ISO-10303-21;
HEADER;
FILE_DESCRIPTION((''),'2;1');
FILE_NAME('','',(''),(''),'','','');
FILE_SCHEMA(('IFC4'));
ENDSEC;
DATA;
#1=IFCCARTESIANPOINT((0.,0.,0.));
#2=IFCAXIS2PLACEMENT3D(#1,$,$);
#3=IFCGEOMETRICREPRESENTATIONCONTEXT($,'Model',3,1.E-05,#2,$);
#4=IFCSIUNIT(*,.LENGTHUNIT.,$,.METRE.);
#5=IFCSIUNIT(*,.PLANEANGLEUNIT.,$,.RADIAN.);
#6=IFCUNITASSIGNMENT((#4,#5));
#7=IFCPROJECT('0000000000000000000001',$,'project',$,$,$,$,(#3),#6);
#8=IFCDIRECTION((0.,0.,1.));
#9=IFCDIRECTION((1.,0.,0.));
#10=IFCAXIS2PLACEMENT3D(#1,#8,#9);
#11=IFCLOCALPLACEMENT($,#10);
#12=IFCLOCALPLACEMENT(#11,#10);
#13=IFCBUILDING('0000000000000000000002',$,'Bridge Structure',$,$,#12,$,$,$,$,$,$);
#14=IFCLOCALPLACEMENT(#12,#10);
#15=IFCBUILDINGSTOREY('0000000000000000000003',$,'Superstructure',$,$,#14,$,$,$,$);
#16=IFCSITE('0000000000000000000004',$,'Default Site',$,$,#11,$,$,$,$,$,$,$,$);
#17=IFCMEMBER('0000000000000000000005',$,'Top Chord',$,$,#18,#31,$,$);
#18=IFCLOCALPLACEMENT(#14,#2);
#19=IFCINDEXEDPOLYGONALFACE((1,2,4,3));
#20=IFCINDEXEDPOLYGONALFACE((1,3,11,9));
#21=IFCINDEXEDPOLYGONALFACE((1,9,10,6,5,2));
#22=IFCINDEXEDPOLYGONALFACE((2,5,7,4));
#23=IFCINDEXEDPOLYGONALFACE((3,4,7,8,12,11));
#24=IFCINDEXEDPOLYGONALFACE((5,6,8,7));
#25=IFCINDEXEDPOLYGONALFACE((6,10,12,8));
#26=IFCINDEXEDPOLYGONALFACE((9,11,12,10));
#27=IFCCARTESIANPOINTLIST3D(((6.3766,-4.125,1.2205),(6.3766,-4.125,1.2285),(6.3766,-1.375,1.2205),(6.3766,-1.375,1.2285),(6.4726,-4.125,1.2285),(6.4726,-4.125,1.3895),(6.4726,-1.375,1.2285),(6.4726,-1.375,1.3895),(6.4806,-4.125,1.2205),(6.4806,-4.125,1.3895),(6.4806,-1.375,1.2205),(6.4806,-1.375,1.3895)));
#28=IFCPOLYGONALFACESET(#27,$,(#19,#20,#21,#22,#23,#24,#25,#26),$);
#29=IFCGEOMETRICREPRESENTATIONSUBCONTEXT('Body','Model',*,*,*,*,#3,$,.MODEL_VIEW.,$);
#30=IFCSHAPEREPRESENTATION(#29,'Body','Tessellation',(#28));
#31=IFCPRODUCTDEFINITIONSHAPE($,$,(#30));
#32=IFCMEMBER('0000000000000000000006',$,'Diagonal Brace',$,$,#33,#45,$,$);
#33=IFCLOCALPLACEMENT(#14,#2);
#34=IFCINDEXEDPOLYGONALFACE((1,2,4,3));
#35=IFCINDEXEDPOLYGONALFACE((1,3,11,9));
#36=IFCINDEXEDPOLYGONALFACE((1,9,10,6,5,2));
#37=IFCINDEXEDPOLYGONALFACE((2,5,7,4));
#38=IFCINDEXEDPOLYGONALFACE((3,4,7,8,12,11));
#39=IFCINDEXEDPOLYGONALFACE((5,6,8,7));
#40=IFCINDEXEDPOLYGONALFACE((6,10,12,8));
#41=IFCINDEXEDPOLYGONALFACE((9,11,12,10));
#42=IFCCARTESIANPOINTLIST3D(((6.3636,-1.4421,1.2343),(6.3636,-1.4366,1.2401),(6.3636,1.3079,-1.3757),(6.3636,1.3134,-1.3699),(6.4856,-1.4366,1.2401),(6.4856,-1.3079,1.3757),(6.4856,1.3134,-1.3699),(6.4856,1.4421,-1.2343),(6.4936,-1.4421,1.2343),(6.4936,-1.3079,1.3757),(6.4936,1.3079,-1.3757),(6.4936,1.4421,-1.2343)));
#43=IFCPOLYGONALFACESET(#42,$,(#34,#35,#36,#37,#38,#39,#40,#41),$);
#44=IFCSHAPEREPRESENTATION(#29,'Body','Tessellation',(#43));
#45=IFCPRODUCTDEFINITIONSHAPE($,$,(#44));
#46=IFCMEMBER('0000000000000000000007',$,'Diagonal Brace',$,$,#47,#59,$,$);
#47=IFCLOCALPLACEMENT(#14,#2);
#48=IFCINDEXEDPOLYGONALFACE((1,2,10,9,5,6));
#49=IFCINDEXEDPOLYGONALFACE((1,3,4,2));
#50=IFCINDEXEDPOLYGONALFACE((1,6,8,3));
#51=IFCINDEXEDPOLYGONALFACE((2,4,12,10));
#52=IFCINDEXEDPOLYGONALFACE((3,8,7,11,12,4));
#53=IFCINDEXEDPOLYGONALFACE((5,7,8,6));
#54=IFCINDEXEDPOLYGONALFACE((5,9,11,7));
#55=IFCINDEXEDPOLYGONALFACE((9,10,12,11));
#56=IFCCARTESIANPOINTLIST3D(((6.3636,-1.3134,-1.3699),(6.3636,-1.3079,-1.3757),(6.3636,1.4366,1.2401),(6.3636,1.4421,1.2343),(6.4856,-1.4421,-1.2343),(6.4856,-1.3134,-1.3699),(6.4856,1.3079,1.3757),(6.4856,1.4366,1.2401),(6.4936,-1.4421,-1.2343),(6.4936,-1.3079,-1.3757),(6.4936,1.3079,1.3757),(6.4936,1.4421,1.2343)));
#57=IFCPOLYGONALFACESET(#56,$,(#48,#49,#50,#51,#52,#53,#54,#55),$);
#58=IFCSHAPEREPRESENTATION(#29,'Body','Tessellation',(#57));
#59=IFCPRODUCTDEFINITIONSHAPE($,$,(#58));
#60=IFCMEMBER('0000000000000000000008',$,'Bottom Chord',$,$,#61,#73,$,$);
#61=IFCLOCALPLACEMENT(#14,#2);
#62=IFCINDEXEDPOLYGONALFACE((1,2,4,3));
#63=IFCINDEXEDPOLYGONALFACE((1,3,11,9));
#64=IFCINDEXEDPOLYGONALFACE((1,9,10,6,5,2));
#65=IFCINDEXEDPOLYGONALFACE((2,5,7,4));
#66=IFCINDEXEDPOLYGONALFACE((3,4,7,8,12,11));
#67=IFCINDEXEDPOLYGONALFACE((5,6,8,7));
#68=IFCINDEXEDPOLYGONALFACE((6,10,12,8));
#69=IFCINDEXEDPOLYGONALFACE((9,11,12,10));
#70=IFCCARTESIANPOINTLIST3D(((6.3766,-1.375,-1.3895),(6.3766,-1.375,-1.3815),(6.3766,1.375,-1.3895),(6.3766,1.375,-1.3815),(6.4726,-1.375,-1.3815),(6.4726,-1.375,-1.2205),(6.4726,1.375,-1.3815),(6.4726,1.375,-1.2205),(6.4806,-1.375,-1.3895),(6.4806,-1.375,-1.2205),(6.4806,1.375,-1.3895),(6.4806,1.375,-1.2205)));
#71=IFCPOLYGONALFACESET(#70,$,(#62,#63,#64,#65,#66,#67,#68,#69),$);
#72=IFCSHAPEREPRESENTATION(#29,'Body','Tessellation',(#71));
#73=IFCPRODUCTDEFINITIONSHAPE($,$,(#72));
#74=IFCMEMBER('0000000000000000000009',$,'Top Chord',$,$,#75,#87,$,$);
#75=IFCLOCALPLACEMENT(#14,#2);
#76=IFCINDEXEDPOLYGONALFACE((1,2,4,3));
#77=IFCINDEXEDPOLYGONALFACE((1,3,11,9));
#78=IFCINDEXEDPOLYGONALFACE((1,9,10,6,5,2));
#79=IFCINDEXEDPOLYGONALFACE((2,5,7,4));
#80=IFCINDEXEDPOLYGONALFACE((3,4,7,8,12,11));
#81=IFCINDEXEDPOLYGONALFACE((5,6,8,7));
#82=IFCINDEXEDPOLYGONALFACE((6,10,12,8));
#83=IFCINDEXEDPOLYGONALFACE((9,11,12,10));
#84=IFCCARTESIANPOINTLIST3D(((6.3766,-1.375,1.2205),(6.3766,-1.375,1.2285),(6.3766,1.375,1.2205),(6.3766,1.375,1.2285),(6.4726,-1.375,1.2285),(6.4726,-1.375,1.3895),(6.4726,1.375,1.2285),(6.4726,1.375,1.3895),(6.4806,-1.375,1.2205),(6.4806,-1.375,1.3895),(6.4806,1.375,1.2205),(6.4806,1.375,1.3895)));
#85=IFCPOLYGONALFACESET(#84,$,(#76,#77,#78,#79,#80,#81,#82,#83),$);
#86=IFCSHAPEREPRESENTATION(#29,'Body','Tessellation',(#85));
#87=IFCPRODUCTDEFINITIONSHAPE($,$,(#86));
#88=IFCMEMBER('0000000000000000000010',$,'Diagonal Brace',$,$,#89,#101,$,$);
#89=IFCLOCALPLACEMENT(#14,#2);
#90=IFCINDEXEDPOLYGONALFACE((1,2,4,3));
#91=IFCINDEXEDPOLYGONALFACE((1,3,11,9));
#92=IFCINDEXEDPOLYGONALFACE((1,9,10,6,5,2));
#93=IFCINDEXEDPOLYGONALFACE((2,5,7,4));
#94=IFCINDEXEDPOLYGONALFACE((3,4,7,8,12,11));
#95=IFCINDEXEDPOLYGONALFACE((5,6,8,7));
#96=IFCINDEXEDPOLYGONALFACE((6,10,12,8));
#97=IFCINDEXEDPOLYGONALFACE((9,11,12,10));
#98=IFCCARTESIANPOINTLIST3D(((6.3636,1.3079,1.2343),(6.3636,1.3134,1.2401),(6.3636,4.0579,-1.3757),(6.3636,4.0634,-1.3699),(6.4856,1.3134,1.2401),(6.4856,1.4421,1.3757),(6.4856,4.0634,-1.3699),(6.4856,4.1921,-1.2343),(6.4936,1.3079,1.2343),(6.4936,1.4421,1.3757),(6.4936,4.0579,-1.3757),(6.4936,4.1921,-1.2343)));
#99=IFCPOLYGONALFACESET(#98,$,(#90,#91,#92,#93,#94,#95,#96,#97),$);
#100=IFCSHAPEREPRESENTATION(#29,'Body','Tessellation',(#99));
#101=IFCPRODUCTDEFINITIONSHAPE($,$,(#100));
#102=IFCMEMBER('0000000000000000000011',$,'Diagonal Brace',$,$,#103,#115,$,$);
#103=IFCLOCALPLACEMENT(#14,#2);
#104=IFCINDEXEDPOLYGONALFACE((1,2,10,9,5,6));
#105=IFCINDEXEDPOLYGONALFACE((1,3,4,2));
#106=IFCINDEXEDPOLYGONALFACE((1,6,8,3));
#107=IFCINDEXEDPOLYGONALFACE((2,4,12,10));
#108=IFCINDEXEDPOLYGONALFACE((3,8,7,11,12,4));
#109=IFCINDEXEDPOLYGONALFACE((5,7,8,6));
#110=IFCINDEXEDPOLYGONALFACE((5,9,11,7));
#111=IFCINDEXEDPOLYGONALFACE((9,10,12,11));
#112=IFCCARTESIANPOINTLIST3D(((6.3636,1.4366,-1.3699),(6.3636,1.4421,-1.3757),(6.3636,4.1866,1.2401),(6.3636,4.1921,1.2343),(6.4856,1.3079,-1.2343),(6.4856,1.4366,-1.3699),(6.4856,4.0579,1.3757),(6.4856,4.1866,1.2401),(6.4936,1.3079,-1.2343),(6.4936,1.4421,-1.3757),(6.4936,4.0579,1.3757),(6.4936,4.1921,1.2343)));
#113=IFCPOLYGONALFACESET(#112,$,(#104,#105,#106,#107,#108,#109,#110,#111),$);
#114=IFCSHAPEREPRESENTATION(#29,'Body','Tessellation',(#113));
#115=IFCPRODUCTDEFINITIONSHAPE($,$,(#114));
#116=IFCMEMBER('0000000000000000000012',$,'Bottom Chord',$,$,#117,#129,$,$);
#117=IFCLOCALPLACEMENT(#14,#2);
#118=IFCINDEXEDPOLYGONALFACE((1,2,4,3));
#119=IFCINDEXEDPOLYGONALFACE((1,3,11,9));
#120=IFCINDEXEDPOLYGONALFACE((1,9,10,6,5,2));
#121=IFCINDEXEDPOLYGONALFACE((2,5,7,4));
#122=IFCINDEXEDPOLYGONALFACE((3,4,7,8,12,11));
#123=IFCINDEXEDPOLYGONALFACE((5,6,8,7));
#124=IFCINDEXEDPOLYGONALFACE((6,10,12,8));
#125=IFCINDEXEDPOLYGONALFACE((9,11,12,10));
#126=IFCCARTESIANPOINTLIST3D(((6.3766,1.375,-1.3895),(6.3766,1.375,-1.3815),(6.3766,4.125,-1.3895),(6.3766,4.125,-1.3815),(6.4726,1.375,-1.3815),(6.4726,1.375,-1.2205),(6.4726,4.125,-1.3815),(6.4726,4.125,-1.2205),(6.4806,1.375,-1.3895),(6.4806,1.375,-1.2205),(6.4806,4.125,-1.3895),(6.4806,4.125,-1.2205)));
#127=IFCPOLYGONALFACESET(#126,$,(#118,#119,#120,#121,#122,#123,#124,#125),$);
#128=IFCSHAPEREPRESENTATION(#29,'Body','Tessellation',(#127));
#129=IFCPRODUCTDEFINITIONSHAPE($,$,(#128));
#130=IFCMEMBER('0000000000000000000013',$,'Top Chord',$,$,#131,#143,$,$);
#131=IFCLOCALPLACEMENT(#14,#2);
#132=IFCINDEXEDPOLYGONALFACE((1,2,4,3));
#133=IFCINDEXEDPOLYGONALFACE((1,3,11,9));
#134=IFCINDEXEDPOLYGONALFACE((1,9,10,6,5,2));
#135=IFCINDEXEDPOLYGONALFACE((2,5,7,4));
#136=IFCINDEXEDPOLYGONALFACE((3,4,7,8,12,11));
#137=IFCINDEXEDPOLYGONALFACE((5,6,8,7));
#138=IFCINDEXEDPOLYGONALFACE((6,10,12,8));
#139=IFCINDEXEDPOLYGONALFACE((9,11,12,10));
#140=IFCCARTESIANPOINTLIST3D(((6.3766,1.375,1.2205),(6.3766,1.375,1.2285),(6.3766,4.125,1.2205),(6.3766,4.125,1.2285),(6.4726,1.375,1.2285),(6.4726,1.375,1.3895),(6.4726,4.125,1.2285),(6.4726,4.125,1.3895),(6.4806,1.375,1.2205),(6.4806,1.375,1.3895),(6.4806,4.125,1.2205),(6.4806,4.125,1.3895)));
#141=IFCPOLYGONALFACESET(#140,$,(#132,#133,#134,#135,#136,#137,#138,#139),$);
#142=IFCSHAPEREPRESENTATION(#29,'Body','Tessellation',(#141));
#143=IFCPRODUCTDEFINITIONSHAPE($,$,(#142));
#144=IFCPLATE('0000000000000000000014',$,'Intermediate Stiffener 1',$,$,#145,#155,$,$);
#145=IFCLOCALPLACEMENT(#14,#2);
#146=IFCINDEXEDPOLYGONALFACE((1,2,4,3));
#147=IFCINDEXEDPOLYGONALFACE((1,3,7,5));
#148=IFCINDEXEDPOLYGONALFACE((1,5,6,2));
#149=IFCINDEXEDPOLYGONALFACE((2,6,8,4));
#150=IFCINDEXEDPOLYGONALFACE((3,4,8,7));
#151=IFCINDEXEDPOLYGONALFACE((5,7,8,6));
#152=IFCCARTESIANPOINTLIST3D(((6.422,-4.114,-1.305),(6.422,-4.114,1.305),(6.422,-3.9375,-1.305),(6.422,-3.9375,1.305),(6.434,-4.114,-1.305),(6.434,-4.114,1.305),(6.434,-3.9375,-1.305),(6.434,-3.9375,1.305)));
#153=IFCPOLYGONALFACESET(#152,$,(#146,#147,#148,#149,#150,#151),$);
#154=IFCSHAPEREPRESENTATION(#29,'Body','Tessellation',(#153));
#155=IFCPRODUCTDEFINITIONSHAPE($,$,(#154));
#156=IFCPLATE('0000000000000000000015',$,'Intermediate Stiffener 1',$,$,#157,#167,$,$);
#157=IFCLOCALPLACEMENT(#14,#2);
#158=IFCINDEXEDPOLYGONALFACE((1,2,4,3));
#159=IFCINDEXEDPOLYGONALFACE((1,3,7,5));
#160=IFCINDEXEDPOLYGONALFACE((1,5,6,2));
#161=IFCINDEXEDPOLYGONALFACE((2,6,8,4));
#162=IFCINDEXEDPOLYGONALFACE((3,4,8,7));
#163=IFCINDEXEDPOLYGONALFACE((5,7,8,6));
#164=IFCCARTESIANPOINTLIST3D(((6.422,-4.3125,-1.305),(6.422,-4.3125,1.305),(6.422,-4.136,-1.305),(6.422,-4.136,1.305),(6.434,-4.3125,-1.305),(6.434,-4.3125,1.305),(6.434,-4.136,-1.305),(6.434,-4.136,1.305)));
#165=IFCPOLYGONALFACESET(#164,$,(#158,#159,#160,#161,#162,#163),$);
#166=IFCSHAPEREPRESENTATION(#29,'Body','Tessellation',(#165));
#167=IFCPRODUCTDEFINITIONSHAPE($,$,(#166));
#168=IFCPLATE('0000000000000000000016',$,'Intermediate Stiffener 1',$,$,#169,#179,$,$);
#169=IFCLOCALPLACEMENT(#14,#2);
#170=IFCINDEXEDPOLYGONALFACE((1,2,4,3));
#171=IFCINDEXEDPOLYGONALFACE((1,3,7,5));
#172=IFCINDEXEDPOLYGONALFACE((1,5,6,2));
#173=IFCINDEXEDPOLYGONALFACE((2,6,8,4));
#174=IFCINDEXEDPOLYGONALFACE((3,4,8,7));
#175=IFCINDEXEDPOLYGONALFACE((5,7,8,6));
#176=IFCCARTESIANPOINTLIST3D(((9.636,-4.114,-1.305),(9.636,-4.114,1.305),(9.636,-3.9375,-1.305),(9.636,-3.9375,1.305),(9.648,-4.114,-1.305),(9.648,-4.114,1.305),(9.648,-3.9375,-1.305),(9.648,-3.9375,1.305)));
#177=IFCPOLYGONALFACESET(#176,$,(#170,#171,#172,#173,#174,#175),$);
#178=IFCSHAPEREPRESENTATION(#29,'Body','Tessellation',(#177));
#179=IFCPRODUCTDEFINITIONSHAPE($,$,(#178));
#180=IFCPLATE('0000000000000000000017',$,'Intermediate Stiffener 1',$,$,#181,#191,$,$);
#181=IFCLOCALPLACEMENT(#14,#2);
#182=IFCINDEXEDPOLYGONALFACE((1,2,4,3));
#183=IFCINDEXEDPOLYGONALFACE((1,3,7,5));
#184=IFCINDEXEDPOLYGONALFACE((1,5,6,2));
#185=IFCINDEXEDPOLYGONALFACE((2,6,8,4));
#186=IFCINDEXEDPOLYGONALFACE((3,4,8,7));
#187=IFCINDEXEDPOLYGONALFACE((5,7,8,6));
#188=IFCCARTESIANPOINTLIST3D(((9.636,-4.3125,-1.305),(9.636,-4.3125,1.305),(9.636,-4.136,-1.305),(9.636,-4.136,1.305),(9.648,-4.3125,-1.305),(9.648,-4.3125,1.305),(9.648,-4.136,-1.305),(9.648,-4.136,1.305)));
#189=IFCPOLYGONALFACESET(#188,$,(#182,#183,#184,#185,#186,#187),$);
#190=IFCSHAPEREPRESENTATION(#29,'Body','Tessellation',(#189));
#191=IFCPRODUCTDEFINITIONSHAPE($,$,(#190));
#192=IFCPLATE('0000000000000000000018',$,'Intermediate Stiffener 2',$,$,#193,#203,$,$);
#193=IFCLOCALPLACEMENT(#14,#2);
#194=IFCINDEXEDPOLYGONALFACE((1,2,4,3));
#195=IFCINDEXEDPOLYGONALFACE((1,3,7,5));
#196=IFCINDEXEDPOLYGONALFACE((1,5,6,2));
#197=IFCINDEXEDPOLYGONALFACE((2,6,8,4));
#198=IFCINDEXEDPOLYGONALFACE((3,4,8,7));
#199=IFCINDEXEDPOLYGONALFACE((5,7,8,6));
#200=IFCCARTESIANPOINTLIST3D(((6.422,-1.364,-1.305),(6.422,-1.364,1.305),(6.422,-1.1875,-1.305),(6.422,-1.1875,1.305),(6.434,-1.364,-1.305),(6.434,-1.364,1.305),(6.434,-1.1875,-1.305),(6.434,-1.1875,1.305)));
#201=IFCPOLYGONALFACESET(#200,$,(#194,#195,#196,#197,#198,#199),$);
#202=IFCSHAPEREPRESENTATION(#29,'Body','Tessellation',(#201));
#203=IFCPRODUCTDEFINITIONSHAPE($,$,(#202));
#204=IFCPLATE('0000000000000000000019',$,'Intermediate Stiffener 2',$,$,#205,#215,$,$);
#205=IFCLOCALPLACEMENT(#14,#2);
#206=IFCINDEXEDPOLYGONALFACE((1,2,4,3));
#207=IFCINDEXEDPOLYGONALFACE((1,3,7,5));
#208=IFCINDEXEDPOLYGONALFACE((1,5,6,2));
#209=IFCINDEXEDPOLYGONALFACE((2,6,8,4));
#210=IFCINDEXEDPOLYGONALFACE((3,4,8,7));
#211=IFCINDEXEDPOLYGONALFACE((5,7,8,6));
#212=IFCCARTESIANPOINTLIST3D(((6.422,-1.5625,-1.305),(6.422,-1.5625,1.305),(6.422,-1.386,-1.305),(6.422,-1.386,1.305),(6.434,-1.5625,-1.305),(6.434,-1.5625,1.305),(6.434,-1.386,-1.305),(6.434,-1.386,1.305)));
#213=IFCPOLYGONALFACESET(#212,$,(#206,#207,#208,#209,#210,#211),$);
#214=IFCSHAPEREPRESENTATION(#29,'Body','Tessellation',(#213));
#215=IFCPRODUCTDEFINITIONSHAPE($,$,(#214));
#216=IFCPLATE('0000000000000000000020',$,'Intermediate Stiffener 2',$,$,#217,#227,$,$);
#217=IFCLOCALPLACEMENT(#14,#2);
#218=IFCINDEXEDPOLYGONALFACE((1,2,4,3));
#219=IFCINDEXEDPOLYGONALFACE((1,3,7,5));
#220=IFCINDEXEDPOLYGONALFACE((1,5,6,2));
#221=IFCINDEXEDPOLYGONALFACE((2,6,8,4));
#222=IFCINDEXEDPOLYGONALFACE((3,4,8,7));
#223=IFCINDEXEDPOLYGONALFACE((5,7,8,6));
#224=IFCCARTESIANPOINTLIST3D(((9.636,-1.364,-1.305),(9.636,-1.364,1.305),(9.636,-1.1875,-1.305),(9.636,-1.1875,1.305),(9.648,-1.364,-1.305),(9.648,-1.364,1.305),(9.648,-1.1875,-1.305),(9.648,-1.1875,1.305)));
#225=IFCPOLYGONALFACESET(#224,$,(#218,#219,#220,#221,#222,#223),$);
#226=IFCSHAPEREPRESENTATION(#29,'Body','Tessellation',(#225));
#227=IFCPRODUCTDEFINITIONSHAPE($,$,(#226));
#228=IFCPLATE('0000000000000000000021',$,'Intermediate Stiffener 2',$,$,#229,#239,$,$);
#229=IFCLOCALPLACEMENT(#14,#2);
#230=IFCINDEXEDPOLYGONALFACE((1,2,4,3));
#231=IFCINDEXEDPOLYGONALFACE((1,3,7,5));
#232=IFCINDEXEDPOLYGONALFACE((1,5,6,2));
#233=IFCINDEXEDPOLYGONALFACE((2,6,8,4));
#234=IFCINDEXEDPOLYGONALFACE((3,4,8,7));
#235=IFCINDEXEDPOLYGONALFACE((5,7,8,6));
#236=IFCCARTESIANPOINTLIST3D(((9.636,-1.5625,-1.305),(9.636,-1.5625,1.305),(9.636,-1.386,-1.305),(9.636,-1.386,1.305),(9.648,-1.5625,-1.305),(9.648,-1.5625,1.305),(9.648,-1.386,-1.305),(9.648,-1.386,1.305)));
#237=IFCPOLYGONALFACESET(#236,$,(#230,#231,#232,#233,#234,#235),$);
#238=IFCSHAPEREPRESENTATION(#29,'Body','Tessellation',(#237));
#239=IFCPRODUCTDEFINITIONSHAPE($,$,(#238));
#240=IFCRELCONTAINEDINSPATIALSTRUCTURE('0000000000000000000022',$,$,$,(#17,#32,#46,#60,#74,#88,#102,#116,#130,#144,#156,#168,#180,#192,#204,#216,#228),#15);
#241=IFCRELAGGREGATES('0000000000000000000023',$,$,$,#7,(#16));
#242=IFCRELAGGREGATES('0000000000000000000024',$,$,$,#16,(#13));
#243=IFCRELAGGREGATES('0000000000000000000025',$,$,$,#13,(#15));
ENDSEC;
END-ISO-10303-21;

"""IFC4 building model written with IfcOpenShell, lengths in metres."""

from ifc_helpers import new_model, si_unit, frame, origin, origin_with_axes, origin_2d_with_axis, place, context, subcontext, project, spatial, rectangle, l_section, extrude, element, save


model = new_model("IFC4")

# Units and contexts
model_context = context("Model", 3, precision=1e-05, world=origin())
body_context = subcontext(model_context, "Body", "Model", "MODEL_VIEW")
ifc_project = project(units=[si_unit("LENGTHUNIT", "METRE"), si_unit("PLANEANGLEUNIT", "RADIAN")], contexts=[model_context])

# Site, building, storey
site_placement = place(None, origin_with_axes())
site = spatial("IfcSite", under=ifc_project, at=site_placement, Name="Default Site")
building_placement = place(site_placement, origin_with_axes())
building = spatial("IfcBuilding", under=site, at=building_placement, Name="Bridge Structure")
storey_placement = place(building_placement, origin_with_axes())
storey = spatial("IfcBuildingStorey", under=building, at=storey_placement, Name="Superstructure")

# Members
for number, where, z_axis, x_axis, name in (
    (1, (6.4286, -4.125, 1.305), (0.0, 1.0, 0.0), (-1.0, 0.0, 0.0), "Top Chord"),
):
    element("IfcMember", number, at=place(storey_placement, frame(where, z_axis=z_axis, x_axis=x_axis)), inside=storey, Name=name, context=body_context, shape_type="SweptSolid", body=[
        extrude(l_section(Depth=0.169, Width=0.104, Thickness=0.008, at=origin_2d_with_axis()), origin_with_axes(), (0.0, 0.0, 1.0), 2.75),
    ])
for number, where, z_axis, x_axis, name in (
    (2, (6.4286, -1.375, 1.305), (0.0, 0.725329, -0.688403), (-1.0, 0.0, 0.0), "Diagonal Brace"),
    (3, (6.4286, -1.375, -1.305), (0.0, 0.725329, 0.688403), (-1.0, 0.0, 0.0), "Diagonal Brace"),
):
    element("IfcMember", number, at=place(storey_placement, frame(where, z_axis=z_axis, x_axis=x_axis)), inside=storey, Name=name, context=body_context, shape_type="SweptSolid", body=[
        extrude(l_section(Depth=0.195, Width=0.13, Thickness=0.008, at=origin_2d_with_axis()), origin_with_axes(), (0.0, 0.0, 1.0), 3.7914),
    ])
for number, where, z_axis, x_axis, name in (
    (4, (6.4286, -1.375, -1.305), (0.0, 1.0, 0.0), (-1.0, 0.0, 0.0), "Bottom Chord"),
    (5, (6.4286, -1.375, 1.305), (0.0, 1.0, 0.0), (-1.0, 0.0, 0.0), "Top Chord"),
):
    element("IfcMember", number, at=place(storey_placement, frame(where, z_axis=z_axis, x_axis=x_axis)), inside=storey, Name=name, context=body_context, shape_type="SweptSolid", body=[
        extrude(l_section(Depth=0.169, Width=0.104, Thickness=0.008, at=origin_2d_with_axis()), origin_with_axes(), (0.0, 0.0, 1.0), 2.75),
    ])
for number, where, z_axis, x_axis, name in (
    (6, (6.4286, 1.375, 1.305), (0.0, 0.725329, -0.688403), (-1.0, 0.0, 0.0), "Diagonal Brace"),
    (7, (6.4286, 1.375, -1.305), (0.0, 0.725329, 0.688403), (-1.0, 0.0, 0.0), "Diagonal Brace"),
):
    element("IfcMember", number, at=place(storey_placement, frame(where, z_axis=z_axis, x_axis=x_axis)), inside=storey, Name=name, context=body_context, shape_type="SweptSolid", body=[
        extrude(l_section(Depth=0.195, Width=0.13, Thickness=0.008, at=origin_2d_with_axis()), origin_with_axes(), (0.0, 0.0, 1.0), 3.7914),
    ])
for number, where, z_axis, x_axis, name in (
    (8, (6.4286, 1.375, -1.305), (0.0, 1.0, 0.0), (-1.0, 0.0, 0.0), "Bottom Chord"),
    (9, (6.4286, 1.375, 1.305), (0.0, 1.0, 0.0), (-1.0, 0.0, 0.0), "Top Chord"),
):
    element("IfcMember", number, at=place(storey_placement, frame(where, z_axis=z_axis, x_axis=x_axis)), inside=storey, Name=name, context=body_context, shape_type="SweptSolid", body=[
        extrude(l_section(Depth=0.169, Width=0.104, Thickness=0.008, at=origin_2d_with_axis()), origin_with_axes(), (0.0, 0.0, 1.0), 2.75),
    ])

# Plates
for number, where, z_axis, x_axis, name in (
    (10, (6.428, -4.0258, -1.305), (0.0, 0.0, 1.0), (1.0, 0.0, 0.0), "Intermediate Stiffener 1"),
    (11, (6.428, -4.2243, -1.305), (0.0, 0.0, 1.0), (1.0, 0.0, 0.0), "Intermediate Stiffener 1"),
    (12, (9.642, -4.0258, -1.305), (0.0, 0.0, 1.0), (1.0, 0.0, 0.0), "Intermediate Stiffener 1"),
    (13, (9.642, -4.2243, -1.305), (0.0, 0.0, 1.0), (1.0, 0.0, 0.0), "Intermediate Stiffener 1"),
    (14, (6.428, -1.2757, -1.305), (0.0, 0.0, 1.0), (1.0, 0.0, 0.0), "Intermediate Stiffener 2"),
    (15, (6.428, -1.4743, -1.305), (0.0, 0.0, 1.0), (1.0, 0.0, 0.0), "Intermediate Stiffener 2"),
    (16, (9.642, -1.2757, -1.305), (0.0, 0.0, 1.0), (1.0, 0.0, 0.0), "Intermediate Stiffener 2"),
    (17, (9.642, -1.4743, -1.305), (0.0, 0.0, 1.0), (1.0, 0.0, 0.0), "Intermediate Stiffener 2"),
):
    element("IfcPlate", number, at=place(storey_placement, frame(where, z_axis=z_axis, x_axis=x_axis)), inside=storey, Name=name, context=body_context, shape_type="SweptSolid", body=[
        extrude(rectangle(XDim=0.012, YDim=0.1765, at=origin_2d_with_axis()), origin_with_axes(), (0.0, 0.0, 1.0), 2.61),
    ])

save(model, "model.ifc")
